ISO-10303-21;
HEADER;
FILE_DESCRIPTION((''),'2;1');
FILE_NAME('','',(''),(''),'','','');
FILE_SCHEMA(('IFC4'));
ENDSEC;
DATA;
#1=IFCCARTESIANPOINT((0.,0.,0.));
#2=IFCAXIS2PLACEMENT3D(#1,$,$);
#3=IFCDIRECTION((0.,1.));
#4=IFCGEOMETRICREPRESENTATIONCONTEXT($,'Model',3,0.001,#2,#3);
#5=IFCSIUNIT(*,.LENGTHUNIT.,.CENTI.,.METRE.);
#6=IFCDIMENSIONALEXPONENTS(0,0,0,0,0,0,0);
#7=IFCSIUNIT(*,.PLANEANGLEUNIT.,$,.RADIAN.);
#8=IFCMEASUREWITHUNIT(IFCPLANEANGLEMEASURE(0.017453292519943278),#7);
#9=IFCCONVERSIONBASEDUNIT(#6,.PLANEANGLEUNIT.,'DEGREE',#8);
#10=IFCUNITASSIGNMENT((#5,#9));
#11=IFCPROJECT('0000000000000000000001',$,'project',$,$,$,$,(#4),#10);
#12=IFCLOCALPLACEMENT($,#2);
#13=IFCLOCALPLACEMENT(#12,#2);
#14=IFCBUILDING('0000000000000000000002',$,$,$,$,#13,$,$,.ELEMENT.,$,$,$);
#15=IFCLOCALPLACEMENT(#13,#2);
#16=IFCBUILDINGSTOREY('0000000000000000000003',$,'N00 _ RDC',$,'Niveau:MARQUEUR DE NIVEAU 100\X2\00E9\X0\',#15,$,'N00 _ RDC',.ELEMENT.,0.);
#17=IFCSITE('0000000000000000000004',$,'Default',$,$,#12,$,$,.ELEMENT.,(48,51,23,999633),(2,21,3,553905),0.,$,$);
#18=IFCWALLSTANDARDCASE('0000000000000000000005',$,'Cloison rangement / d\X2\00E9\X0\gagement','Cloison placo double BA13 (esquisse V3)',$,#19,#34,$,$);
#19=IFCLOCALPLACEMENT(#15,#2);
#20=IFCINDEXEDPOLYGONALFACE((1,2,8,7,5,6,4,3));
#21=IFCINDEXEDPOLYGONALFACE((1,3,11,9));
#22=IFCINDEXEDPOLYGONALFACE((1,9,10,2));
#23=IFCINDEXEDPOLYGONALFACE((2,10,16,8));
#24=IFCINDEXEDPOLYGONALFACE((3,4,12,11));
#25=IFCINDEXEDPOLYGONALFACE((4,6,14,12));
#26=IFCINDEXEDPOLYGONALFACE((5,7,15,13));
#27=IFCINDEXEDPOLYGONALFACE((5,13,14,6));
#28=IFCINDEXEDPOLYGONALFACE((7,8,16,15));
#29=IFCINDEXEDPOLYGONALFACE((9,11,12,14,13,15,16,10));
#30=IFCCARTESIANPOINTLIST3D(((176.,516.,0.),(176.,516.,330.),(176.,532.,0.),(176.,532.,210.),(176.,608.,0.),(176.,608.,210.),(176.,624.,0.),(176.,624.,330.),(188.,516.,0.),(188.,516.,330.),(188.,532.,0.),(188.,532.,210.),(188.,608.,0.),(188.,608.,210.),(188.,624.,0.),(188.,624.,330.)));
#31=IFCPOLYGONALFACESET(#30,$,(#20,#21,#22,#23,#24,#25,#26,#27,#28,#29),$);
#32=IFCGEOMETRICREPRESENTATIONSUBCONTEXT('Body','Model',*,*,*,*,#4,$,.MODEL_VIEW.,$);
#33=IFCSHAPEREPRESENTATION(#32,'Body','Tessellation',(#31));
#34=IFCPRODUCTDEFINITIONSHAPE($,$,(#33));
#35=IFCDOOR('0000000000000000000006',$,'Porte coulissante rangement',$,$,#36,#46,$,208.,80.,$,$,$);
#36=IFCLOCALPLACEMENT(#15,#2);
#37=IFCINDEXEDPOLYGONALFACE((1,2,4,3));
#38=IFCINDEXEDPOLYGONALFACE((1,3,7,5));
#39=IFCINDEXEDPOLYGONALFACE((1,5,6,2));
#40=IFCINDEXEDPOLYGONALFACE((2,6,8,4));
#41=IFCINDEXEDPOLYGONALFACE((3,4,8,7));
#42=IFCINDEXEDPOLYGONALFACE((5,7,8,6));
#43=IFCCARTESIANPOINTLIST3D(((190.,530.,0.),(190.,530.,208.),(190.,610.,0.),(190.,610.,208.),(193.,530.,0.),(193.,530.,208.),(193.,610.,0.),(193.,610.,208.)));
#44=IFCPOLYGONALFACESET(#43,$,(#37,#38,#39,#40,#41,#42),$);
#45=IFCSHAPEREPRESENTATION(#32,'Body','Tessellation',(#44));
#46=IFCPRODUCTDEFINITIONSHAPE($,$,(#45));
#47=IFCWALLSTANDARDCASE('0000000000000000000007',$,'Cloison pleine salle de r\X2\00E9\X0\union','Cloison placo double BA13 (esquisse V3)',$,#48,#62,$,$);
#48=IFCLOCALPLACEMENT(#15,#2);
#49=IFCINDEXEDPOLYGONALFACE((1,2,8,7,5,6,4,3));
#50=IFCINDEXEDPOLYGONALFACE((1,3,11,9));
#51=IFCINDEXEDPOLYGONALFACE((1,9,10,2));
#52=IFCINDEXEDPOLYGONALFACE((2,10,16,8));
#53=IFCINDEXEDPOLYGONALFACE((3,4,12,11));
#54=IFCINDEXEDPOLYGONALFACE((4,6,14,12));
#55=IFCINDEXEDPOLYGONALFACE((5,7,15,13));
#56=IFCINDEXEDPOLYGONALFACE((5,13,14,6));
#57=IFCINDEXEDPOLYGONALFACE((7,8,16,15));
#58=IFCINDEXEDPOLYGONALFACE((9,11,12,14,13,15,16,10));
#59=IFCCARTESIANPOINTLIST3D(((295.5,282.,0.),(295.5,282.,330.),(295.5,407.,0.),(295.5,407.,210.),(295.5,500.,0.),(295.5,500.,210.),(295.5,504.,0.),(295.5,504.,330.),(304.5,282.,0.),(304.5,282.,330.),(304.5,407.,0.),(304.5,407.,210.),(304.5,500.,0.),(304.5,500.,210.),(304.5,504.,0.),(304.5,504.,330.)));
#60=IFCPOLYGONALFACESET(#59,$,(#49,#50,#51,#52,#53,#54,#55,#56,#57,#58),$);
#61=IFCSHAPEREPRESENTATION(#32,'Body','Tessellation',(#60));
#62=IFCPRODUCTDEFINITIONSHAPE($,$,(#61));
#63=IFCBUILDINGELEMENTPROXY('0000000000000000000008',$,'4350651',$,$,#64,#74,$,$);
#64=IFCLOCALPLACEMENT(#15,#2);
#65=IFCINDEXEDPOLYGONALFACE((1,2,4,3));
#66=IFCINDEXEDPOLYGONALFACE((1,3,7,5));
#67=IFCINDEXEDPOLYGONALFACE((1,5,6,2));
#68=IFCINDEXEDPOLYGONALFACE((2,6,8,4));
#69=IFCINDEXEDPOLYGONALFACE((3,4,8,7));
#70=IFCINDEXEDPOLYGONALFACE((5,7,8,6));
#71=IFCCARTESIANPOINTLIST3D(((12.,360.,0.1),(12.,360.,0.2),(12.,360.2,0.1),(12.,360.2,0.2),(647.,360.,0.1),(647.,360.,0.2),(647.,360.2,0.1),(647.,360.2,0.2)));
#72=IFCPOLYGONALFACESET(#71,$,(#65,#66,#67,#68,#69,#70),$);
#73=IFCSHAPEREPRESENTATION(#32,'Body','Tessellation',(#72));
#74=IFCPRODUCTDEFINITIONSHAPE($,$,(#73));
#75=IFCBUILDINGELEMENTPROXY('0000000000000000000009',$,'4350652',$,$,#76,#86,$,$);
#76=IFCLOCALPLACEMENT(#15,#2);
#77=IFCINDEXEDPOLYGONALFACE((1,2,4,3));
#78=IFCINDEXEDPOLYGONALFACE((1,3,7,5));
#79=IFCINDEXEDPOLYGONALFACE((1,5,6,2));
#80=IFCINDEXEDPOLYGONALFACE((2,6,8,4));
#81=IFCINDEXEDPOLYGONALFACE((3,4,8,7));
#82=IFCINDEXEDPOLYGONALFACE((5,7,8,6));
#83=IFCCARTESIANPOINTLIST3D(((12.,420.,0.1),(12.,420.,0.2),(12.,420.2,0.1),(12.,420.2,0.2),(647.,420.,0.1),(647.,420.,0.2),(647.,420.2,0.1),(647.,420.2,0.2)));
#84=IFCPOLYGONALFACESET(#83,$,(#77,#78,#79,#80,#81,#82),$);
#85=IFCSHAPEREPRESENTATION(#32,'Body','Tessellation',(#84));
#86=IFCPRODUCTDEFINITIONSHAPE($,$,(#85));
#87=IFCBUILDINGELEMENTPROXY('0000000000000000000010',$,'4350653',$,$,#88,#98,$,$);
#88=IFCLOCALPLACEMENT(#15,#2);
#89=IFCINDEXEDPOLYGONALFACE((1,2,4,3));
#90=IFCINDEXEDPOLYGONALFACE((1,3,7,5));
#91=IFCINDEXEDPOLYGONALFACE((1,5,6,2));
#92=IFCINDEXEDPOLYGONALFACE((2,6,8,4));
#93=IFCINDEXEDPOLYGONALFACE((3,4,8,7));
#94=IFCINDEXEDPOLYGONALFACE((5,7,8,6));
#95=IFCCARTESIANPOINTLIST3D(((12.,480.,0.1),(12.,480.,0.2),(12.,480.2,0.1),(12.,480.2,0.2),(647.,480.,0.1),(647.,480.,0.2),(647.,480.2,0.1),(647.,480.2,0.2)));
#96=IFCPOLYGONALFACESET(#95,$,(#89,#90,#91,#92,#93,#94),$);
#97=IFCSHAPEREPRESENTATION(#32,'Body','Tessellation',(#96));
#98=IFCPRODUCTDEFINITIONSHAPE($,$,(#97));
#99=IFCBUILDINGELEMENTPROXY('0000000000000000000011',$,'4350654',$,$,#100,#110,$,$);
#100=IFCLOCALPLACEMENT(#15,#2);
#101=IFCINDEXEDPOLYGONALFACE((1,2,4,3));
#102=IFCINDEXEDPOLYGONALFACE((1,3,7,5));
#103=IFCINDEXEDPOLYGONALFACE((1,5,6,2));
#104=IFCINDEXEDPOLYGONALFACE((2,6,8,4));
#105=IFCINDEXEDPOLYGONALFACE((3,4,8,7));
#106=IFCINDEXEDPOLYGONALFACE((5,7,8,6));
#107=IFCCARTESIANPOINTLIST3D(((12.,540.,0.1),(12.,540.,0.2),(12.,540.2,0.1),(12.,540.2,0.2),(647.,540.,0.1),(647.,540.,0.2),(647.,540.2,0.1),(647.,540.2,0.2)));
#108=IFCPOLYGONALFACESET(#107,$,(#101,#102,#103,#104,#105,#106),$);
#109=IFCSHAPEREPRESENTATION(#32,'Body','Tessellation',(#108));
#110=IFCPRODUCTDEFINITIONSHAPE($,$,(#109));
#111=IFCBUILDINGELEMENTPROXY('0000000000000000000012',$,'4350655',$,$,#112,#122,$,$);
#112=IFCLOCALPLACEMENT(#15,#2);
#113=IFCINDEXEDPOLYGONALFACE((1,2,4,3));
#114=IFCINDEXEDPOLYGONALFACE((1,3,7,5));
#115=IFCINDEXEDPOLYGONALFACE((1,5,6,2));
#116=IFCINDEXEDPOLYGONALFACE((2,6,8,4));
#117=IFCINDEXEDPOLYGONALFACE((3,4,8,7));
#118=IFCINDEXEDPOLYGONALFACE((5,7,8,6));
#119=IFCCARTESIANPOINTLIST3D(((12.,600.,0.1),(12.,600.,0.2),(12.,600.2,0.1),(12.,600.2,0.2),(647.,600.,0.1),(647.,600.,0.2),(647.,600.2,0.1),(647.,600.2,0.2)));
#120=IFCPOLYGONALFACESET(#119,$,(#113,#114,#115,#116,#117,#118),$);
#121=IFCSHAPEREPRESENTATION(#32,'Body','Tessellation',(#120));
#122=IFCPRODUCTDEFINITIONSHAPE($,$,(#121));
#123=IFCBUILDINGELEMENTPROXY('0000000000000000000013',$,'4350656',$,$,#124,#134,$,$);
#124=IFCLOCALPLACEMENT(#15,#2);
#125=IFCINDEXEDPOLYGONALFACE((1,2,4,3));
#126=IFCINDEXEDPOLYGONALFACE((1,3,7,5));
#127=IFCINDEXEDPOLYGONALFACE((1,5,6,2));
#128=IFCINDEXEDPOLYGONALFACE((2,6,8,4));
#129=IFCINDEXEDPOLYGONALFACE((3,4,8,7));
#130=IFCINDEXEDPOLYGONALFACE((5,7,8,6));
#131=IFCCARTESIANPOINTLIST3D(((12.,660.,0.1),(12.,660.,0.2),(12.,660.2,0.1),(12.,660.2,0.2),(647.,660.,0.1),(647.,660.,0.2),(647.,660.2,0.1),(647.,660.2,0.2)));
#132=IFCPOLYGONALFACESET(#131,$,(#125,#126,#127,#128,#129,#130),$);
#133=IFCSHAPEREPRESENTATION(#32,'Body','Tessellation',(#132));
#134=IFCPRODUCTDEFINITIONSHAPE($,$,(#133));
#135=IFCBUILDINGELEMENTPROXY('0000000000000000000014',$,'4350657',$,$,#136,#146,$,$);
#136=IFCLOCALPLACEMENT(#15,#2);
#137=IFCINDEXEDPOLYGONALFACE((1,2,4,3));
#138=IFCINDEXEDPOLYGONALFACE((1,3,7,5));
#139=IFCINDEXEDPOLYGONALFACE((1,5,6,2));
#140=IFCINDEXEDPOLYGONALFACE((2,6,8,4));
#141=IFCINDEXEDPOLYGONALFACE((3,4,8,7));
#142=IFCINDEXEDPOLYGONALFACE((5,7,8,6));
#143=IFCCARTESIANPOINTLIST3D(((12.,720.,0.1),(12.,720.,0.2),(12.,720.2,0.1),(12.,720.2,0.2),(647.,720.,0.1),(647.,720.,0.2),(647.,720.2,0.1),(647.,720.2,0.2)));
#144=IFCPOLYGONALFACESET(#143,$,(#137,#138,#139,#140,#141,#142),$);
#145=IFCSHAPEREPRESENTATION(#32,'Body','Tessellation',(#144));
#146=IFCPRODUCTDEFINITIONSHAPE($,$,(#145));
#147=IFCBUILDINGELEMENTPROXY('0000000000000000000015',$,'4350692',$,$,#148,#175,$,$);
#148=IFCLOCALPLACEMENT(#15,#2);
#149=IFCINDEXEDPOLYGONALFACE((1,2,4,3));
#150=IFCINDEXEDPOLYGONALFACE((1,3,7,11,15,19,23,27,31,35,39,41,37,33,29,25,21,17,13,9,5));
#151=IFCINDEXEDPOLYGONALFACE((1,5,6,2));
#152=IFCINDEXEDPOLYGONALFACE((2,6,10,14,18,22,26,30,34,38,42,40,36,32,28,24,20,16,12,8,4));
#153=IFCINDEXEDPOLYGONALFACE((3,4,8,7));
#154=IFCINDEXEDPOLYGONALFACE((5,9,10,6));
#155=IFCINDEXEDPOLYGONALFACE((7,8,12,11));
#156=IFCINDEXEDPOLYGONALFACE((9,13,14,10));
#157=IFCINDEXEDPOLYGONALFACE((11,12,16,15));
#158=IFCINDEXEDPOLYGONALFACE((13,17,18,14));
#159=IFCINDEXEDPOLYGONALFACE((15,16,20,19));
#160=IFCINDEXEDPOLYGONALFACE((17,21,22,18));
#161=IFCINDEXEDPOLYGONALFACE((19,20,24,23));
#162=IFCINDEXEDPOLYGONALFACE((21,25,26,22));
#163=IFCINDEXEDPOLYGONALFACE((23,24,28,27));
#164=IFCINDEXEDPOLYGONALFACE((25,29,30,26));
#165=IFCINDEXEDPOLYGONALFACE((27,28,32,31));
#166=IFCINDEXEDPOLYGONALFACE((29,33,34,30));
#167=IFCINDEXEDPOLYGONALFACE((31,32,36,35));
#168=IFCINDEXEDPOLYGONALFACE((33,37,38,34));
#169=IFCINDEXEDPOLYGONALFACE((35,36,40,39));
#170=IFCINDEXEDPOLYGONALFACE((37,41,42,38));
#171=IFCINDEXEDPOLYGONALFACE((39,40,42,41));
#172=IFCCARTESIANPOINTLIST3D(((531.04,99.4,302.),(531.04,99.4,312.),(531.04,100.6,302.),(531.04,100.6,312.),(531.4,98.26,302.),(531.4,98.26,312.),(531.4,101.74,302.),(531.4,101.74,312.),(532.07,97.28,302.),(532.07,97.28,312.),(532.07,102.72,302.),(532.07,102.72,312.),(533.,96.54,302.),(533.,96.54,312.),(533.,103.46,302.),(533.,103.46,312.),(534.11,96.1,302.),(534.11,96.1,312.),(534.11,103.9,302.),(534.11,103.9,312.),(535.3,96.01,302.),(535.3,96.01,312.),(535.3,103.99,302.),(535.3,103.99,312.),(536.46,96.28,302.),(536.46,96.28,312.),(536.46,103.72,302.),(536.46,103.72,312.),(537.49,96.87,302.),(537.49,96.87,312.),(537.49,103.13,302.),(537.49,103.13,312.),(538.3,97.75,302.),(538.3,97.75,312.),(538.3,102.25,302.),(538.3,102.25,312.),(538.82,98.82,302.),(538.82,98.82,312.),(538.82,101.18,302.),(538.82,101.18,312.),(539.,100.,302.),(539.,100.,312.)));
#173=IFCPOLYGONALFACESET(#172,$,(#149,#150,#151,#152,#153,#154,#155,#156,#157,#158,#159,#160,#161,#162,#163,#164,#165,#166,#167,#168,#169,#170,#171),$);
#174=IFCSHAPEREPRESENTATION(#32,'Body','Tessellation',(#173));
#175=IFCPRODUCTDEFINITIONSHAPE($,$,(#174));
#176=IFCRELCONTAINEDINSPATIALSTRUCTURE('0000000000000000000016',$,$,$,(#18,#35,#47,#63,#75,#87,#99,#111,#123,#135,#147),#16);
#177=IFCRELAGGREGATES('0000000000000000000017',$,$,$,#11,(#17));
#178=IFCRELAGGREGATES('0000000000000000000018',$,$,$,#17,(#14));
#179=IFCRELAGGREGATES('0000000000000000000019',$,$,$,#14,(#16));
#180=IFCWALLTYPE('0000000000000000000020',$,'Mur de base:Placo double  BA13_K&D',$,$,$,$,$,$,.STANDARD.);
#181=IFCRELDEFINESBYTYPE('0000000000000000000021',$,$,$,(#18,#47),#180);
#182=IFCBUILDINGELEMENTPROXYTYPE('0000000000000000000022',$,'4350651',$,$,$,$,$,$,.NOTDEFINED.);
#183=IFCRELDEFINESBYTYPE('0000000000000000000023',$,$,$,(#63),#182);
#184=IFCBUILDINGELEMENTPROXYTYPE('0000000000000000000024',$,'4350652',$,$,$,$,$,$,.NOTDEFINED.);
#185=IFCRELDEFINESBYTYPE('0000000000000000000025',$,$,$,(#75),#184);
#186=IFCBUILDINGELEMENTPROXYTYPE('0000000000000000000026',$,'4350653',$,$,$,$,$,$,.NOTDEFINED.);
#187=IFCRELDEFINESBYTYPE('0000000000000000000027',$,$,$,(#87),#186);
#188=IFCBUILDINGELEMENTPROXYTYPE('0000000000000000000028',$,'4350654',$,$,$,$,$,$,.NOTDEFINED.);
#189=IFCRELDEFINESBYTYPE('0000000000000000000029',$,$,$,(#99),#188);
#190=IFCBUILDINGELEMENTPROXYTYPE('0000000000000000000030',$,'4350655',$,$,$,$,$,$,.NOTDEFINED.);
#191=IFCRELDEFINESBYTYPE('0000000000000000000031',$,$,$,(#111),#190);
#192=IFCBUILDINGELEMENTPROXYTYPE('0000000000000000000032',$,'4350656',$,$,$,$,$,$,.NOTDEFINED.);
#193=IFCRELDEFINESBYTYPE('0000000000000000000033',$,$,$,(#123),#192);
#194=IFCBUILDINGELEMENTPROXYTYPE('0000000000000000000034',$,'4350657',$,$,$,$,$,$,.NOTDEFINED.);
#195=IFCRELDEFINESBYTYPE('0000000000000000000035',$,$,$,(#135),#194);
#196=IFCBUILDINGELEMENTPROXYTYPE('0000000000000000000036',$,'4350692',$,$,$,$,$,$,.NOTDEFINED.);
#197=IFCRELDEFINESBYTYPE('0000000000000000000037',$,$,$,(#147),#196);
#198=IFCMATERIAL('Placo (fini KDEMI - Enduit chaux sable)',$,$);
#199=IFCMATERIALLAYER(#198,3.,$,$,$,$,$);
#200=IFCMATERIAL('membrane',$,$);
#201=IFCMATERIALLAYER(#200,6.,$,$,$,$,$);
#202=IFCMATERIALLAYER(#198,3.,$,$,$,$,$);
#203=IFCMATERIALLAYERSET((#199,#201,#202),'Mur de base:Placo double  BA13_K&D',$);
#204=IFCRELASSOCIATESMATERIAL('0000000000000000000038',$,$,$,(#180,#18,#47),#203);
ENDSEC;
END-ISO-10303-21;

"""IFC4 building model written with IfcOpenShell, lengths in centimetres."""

from ifc_helpers import new_model, entity, si_unit, converted_unit, direction, frame, frame_2d, origin, origin_with_axes, origin_2d_with_axis, place, context, subcontext, project, spatial, rectangle, circle, extrude, material, layer, layer_set, layer_usage, type_object, element, fill, save


model = new_model("IFC4")

# Units and contexts
model_context = context("Model", 3, precision=0.001, world=origin(), true_north=direction((0.0, 1.0)))
body_context = subcontext(model_context, "Body", "Model", "MODEL_VIEW")
ifc_project = project(units=[si_unit("LENGTHUNIT", "METRE", prefix="CENTI"), converted_unit("PLANEANGLEUNIT", "DEGREE", entity("IfcPlaneAngleMeasure", 0.017453292519943278), si_unit("PLANEANGLEUNIT", "RADIAN"), dimensions=[0, 0, 0, 0, 0, 0, 0])], contexts=[model_context])

# Site, building, storey
site_placement = place(None, origin())
site = spatial("IfcSite", under=ifc_project, at=site_placement, Name="Default", CompositionType="ELEMENT", RefLatitude=(48, 51, 23, 999633), RefLongitude=(2, 21, 3, 553905), RefElevation=0.0)
building_placement = place(site_placement, origin())
building = spatial("IfcBuilding", under=site, at=building_placement, CompositionType="ELEMENT")
storey_placement = place(building_placement, origin())
storey = spatial("IfcBuildingStorey", under=building, at=storey_placement, Name="N00 _ RDC", ObjectType="Niveau:MARQUEUR DE NIVEAU 100é", LongName="N00 _ RDC", CompositionType="ELEMENT", Elevation=0.0)

# Wall, opening, door
ifc_material_1 = material(Name="Placo (fini KDEMI - Enduit chaux sable)")
ifc_layer_1 = layer(ifc_material_1, 3.0)
ifc_material_2 = material(Name="membrane")
ifc_layer_2 = layer(ifc_material_2, 6.0)
ifc_layer_3 = layer(ifc_material_1, 3.0)
ifc_layer_set = layer_set([ifc_layer_1, ifc_layer_2, ifc_layer_3], Name="Mur de base:Placo double  BA13_K&D")
ifc_layer_usage_1 = layer_usage(ifc_layer_set, "AXIS2", "POSITIVE", 0.0)
wall_type = type_object("IfcWallType", Name="Mur de base:Placo double  BA13_K&D", PredefinedType="STANDARD", material=ifc_layer_set)
wall_1_placement = place(storey_placement, origin_with_axes())
wall_1 = element("IfcWallStandardCase", 1, at=wall_1_placement, inside=storey, type_object=wall_type, material=ifc_layer_usage_1, Name="Cloison rangement / dégagement", Description="Cloison placo double BA13 (esquisse V3)", context=body_context, shape_type="SweptSolid", body=[
    extrude(rectangle(XDim=12.0, YDim=108.0, at=frame_2d((182.0, 570.0))), origin(), (0.0, 0.0, 1.0), 330.0),
])
opening_1_placement = place(wall_1_placement, origin_with_axes())
opening_1 = element("IfcOpeningElement", 2, at=opening_1_placement, inside=storey, cuts=wall_1, context=body_context, shape_type="SweptSolid", body=[
    extrude(rectangle(XDim=16.0, YDim=76.0, at=frame_2d((182.0, 570.0))), origin(), (0.0, 0.0, 1.0), 210.0),
])
door_placement = place(storey_placement, origin_with_axes())
door = element("IfcDoor", 3, at=door_placement, inside=storey, Name="Porte coulissante rangement", OverallHeight=208.0, OverallWidth=80.0, context=body_context, shape_type="SweptSolid", body=[
    extrude(rectangle(XDim=3.0, YDim=80.0, at=frame_2d((191.5, 570.0))), origin(), (0.0, 0.0, 1.0), 208.0),
])
fill(opening_1, door)

# Wall, opening
ifc_layer_usage_2 = layer_usage(ifc_layer_set, "AXIS2", "POSITIVE", 0.0)
wall_2_placement = place(storey_placement, origin_with_axes())
wall_2 = element("IfcWallStandardCase", 4, at=wall_2_placement, inside=storey, type_object=wall_type, material=ifc_layer_usage_2, Name="Cloison pleine salle de réunion", Description="Cloison placo double BA13 (esquisse V3)", context=body_context, shape_type="SweptSolid", body=[
    extrude(rectangle(XDim=9.0, YDim=222.0, at=frame_2d((300.0, 393.0))), origin(), (0.0, 0.0, 1.0), 330.0),
])
opening_2_placement = place(wall_2_placement, origin_with_axes())
element("IfcOpeningElement", 5, at=opening_2_placement, inside=storey, cuts=wall_2, context=body_context, shape_type="SweptSolid", body=[
    extrude(rectangle(XDim=12.0, YDim=93.0, at=frame_2d((300.0, 453.5))), origin(), (0.0, 0.0, 1.0), 210.0),
])

# Building element proxies
building_element_proxy_type_1 = type_object("IfcBuildingElementProxyType", Name="4350651", PredefinedType="NOTDEFINED")
proxy_1_placement = place(storey_placement, origin())
element("IfcBuildingElementProxy", 6, at=proxy_1_placement, inside=storey, type_object=building_element_proxy_type_1, Name="4350651", context=body_context, shape_type="SweptSolid", body=[
    extrude(rectangle(XDim=635.0, YDim=0.2, at=frame_2d((0.0, 0.0), x_axis=(1.0, 0.0))), frame((329.5, 360.1, 0.1)), (0.0, 0.0, 1.0), 0.1),
])
building_element_proxy_type_2 = type_object("IfcBuildingElementProxyType", Name="4350652", PredefinedType="NOTDEFINED")
proxy_2_placement = place(storey_placement, origin())
element("IfcBuildingElementProxy", 7, at=proxy_2_placement, inside=storey, type_object=building_element_proxy_type_2, Name="4350652", context=body_context, shape_type="SweptSolid", body=[
    extrude(rectangle(XDim=635.0, YDim=0.2, at=frame_2d((0.0, 0.0), x_axis=(1.0, 0.0))), frame((329.5, 420.1, 0.1)), (0.0, 0.0, 1.0), 0.1),
])
building_element_proxy_type_3 = type_object("IfcBuildingElementProxyType", Name="4350653", PredefinedType="NOTDEFINED")
proxy_3_placement = place(storey_placement, origin())
element("IfcBuildingElementProxy", 8, at=proxy_3_placement, inside=storey, type_object=building_element_proxy_type_3, Name="4350653", context=body_context, shape_type="SweptSolid", body=[
    extrude(rectangle(XDim=635.0, YDim=0.2, at=frame_2d((0.0, 0.0), x_axis=(1.0, 0.0))), frame((329.5, 480.1, 0.1)), (0.0, 0.0, 1.0), 0.1),
])
building_element_proxy_type_4 = type_object("IfcBuildingElementProxyType", Name="4350654", PredefinedType="NOTDEFINED")
proxy_4_placement = place(storey_placement, origin())
element("IfcBuildingElementProxy", 9, at=proxy_4_placement, inside=storey, type_object=building_element_proxy_type_4, Name="4350654", context=body_context, shape_type="SweptSolid", body=[
    extrude(rectangle(XDim=635.0, YDim=0.2, at=frame_2d((0.0, 0.0), x_axis=(1.0, 0.0))), frame((329.5, 540.1, 0.1)), (0.0, 0.0, 1.0), 0.1),
])
building_element_proxy_type_5 = type_object("IfcBuildingElementProxyType", Name="4350655", PredefinedType="NOTDEFINED")
proxy_5_placement = place(storey_placement, origin())
element("IfcBuildingElementProxy", 10, at=proxy_5_placement, inside=storey, type_object=building_element_proxy_type_5, Name="4350655", context=body_context, shape_type="SweptSolid", body=[
    extrude(rectangle(XDim=635.0, YDim=0.2, at=frame_2d((0.0, 0.0), x_axis=(1.0, 0.0))), frame((329.5, 600.1, 0.1)), (0.0, 0.0, 1.0), 0.1),
])
building_element_proxy_type_6 = type_object("IfcBuildingElementProxyType", Name="4350656", PredefinedType="NOTDEFINED")
proxy_6_placement = place(storey_placement, origin())
element("IfcBuildingElementProxy", 11, at=proxy_6_placement, inside=storey, type_object=building_element_proxy_type_6, Name="4350656", context=body_context, shape_type="SweptSolid", body=[
    extrude(rectangle(XDim=635.0, YDim=0.2, at=frame_2d((0.0, 0.0), x_axis=(1.0, 0.0))), frame((329.5, 660.1, 0.1)), (0.0, 0.0, 1.0), 0.1),
])
building_element_proxy_type_7 = type_object("IfcBuildingElementProxyType", Name="4350657", PredefinedType="NOTDEFINED")
proxy_7_placement = place(storey_placement, origin())
element("IfcBuildingElementProxy", 12, at=proxy_7_placement, inside=storey, type_object=building_element_proxy_type_7, Name="4350657", context=body_context, shape_type="SweptSolid", body=[
    extrude(rectangle(XDim=635.0, YDim=0.2, at=frame_2d((0.0, 0.0), x_axis=(1.0, 0.0))), frame((329.5, 720.1, 0.1)), (0.0, 0.0, 1.0), 0.1),
])
building_element_proxy_type_8 = type_object("IfcBuildingElementProxyType", Name="4350692", PredefinedType="NOTDEFINED")
proxy_8_placement = place(storey_placement, origin())
element("IfcBuildingElementProxy", 13, at=proxy_8_placement, inside=storey, type_object=building_element_proxy_type_8, Name="4350692", context=body_context, shape_type="SweptSolid", body=[
    extrude(circle(Radius=4.0, at=origin_2d_with_axis()), frame((535.0, 100.0, 302.0)), (0.0, 0.0, 1.0), 10.0),
])

save(model, "model.ifc")
